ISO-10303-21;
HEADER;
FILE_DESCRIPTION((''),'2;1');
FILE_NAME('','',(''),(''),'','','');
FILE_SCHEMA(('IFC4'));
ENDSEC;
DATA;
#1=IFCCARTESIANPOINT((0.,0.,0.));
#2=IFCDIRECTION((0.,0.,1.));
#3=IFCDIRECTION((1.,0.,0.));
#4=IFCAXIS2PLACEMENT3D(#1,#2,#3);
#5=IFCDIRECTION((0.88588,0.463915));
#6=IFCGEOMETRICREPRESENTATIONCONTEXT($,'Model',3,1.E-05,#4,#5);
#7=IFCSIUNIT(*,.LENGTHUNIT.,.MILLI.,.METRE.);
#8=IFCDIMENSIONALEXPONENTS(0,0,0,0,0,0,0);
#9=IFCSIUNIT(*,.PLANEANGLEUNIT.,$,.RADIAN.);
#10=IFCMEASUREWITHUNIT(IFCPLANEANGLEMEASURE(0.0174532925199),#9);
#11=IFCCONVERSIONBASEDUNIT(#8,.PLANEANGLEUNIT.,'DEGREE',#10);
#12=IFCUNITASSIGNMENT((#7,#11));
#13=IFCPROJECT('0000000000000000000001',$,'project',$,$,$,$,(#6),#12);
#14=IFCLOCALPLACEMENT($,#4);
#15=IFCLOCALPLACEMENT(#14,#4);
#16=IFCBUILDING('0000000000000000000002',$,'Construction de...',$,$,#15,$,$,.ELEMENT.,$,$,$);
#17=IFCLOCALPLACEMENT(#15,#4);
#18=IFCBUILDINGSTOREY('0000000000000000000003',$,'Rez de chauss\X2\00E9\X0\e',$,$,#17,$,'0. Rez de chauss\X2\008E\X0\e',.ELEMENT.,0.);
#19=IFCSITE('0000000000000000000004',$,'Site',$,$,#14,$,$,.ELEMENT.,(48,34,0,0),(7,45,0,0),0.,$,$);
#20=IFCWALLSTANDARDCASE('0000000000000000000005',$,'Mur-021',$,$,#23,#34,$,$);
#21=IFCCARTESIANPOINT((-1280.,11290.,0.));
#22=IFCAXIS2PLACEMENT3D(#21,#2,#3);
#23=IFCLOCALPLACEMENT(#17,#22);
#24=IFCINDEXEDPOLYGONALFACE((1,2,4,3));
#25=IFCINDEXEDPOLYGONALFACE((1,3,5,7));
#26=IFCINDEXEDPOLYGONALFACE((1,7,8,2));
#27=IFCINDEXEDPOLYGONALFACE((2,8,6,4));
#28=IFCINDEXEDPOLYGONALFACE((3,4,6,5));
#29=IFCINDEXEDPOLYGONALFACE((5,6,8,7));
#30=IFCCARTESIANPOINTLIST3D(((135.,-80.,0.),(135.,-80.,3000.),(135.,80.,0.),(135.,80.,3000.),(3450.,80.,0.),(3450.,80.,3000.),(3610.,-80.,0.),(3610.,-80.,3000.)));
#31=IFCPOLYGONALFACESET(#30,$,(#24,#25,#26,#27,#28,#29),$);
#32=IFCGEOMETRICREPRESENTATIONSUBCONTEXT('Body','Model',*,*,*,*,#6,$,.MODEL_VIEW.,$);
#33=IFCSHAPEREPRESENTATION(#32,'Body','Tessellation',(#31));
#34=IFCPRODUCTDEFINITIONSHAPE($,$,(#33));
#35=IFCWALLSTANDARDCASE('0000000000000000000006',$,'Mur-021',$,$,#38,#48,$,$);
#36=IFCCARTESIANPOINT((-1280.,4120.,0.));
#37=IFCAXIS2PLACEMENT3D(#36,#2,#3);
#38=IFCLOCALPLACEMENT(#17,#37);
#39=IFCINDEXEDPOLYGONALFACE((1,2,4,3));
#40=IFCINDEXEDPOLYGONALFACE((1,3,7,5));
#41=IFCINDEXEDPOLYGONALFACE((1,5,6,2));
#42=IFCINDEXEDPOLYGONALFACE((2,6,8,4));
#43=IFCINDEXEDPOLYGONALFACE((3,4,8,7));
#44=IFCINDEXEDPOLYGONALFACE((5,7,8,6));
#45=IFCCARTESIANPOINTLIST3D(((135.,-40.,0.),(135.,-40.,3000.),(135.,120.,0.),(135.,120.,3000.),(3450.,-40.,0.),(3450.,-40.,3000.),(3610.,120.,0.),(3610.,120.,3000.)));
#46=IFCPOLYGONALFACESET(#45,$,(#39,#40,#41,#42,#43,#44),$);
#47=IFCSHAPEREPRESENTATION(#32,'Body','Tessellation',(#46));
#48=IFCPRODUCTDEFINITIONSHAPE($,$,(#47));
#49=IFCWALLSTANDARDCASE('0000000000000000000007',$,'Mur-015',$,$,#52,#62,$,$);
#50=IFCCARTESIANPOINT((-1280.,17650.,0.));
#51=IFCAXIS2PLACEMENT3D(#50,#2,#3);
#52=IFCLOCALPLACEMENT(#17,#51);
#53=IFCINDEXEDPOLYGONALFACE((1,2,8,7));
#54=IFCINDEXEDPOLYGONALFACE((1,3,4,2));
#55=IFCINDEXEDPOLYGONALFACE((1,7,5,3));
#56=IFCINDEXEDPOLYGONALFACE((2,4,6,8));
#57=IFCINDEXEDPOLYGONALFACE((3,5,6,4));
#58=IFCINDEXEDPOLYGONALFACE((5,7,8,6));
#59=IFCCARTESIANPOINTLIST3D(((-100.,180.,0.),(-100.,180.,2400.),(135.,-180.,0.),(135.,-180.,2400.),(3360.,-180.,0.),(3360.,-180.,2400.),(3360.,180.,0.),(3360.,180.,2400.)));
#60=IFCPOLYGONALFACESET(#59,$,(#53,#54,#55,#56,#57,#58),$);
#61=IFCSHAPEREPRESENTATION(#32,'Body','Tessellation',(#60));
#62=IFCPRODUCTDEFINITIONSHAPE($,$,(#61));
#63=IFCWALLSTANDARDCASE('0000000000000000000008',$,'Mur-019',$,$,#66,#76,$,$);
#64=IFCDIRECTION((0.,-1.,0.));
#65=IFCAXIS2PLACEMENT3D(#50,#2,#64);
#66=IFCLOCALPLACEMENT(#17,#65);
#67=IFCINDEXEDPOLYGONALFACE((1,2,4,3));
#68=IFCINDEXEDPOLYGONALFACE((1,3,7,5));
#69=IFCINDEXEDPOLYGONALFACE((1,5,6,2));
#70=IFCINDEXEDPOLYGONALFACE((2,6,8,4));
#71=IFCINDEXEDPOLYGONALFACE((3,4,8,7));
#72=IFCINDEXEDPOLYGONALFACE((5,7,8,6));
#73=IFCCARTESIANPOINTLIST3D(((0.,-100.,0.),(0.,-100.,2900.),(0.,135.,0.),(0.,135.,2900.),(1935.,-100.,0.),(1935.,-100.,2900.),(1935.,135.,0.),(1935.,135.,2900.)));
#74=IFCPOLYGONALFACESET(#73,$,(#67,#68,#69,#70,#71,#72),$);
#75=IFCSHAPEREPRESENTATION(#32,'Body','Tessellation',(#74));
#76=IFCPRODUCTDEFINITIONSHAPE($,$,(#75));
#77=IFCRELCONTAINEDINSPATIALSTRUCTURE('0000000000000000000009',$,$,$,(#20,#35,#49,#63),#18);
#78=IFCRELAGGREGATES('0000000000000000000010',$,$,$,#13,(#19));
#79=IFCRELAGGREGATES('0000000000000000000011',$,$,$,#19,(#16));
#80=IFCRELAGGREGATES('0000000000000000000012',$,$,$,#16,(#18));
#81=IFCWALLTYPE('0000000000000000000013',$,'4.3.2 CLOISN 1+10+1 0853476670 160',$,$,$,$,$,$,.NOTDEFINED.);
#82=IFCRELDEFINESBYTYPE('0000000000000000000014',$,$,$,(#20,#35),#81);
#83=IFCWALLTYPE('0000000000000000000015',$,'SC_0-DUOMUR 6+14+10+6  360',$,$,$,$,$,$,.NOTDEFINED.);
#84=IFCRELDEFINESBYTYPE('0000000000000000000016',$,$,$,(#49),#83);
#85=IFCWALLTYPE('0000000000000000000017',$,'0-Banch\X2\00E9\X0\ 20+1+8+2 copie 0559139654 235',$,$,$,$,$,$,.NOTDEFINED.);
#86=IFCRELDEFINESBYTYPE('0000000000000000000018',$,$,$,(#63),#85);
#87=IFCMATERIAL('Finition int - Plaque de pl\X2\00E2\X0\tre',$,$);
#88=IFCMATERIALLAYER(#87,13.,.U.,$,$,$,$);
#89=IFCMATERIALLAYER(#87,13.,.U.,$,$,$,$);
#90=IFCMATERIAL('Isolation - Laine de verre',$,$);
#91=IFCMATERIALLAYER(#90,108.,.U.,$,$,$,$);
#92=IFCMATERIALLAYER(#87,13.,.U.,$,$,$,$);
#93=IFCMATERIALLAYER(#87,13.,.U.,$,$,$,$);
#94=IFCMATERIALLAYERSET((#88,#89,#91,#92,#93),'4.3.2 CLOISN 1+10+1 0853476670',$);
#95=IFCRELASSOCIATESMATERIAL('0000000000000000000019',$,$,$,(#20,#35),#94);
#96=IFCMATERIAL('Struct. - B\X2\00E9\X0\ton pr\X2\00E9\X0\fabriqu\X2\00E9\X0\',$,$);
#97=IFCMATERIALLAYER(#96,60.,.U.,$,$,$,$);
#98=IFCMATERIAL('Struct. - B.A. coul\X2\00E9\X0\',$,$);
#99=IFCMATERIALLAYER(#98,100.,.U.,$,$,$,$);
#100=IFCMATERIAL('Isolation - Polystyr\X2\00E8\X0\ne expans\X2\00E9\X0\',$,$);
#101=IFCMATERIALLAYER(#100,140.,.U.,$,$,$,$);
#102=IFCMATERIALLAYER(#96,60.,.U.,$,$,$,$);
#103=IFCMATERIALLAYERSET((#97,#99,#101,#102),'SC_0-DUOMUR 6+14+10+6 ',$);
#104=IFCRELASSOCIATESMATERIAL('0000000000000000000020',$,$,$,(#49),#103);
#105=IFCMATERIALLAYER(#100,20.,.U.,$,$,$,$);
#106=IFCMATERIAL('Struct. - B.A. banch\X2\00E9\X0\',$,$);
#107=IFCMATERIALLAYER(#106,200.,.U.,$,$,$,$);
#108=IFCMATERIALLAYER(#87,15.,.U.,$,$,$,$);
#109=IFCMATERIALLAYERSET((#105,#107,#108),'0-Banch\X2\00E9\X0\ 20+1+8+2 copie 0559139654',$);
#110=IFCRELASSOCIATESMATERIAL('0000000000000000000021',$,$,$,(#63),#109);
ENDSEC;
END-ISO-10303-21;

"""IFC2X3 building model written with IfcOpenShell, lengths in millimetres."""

from ifc_helpers import new_model, entity, si_unit, converted_unit, direction, frame, origin_with_axes, place, context, subcontext, project, spatial, polyline, outline, extrude, clip, halfspace, material, layer, layer_set, layer_usage, type_object, element, save


model = new_model("IFC2X3")

# Units and contexts
model_context = context("Model", 3, precision=1e-05, world=origin_with_axes(), true_north=direction((0.88588, 0.463915)))
body_context = subcontext(model_context, "Body", "Model", "MODEL_VIEW")
ifc_project = project(units=[si_unit("LENGTHUNIT", "METRE", prefix="MILLI"), converted_unit("PLANEANGLEUNIT", "DEGREE", entity("IfcPlaneAngleMeasure", 0.0174532925199), si_unit("PLANEANGLEUNIT", "RADIAN"), dimensions=[0, 0, 0, 0, 0, 0, 0])], contexts=[model_context])

# Site, building, storey
site_placement = place(None, origin_with_axes())
site = spatial("IfcSite", under=ifc_project, at=site_placement, Name="Site", CompositionType="ELEMENT", RefLatitude=(48, 34, 0, 0), RefLongitude=(7, 45, 0, 0), RefElevation=0.0)
building_placement = place(site_placement, origin_with_axes())
building = spatial("IfcBuilding", under=site, at=building_placement, Name="Construction de...", CompositionType="ELEMENT")
storey_placement = place(building_placement, origin_with_axes())
storey = spatial("IfcBuildingStorey", under=building, at=storey_placement, Name="Rez de chaussée", LongName="0. Rez de chauss\u008ee", CompositionType="ELEMENT", Elevation=0.0)

# Shared definitions
ifc_material_1 = material(Name="Struct. - B.A. coulé")

# Wall
ifc_material_2 = material(Name="Finition int - Plaque de plâtre")
ifc_layer_1 = layer(ifc_material_2, 13.0, ventilated="UNKNOWN")
ifc_layer_2 = layer(ifc_material_2, 13.0, ventilated="UNKNOWN")
ifc_material_3 = material(Name="Isolation - Laine de verre")
ifc_layer_3 = layer(ifc_material_3, 108.0, ventilated="UNKNOWN")
ifc_layer_4 = layer(ifc_material_2, 13.0, ventilated="UNKNOWN")
ifc_layer_5 = layer(ifc_material_2, 13.0, ventilated="UNKNOWN")
ifc_layer_set_1 = layer_set([ifc_layer_1, ifc_layer_2, ifc_layer_3, ifc_layer_4, ifc_layer_5], Name="4.3.2 CLOISN 1+10+1 0853476670")
ifc_layer_usage_1 = layer_usage(ifc_layer_set_1, "AXIS2", "NEGATIVE", 80.0)
wall_type_1 = type_object("IfcWallType", Name="4.3.2 CLOISN 1+10+1 0853476670 160", PredefinedType="NOTDEFINED")
wall_1_placement = place(storey_placement, frame((-1280.0, 11290.0, 0.0), z_axis=(0.0, 0.0, 1.0), x_axis=(1.0, 0.0, 0.0)))
element("IfcWallStandardCase", 1, at=wall_1_placement, inside=storey, type_object=wall_type_1, material=ifc_layer_usage_1, Name="Mur-021", context=body_context, shape_type="SweptSolid", body=[
    extrude(outline(polyline([(135.0, -80.0), (3610.0, -80.0), (3450.0, 80.0), (135.0, 80.0), (135.0, -80.0)])), origin_with_axes(), (0.0, 0.0, 1.0), 3000.0),
])

# Wall
ifc_layer_usage_2 = layer_usage(ifc_layer_set_1, "AXIS2", "POSITIVE", -40.0)
wall_2_placement = place(storey_placement, frame((-1280.0, 4120.0, 0.0), z_axis=(0.0, 0.0, 1.0), x_axis=(1.0, 0.0, 0.0)))
element("IfcWallStandardCase", 2, at=wall_2_placement, inside=storey, type_object=wall_type_1, material=ifc_layer_usage_2, Name="Mur-021", context=body_context, shape_type="SweptSolid", body=[
    extrude(outline(polyline([(135.0, -40.0), (3450.0, -40.0), (3610.0, 120.0), (135.0, 120.0), (135.0, -40.0)])), origin_with_axes(), (0.0, 0.0, 1.0), 3000.0),
])
ifc_material_4 = material(Name="Struct. - B.A. banché")

# Shared definitions
ifc_material_5 = material(Name="Struct. - Béton préfabriqué")
ifc_layer_6 = layer(ifc_material_5, 60.0, ventilated="UNKNOWN")
ifc_layer_7 = layer(ifc_material_1, 100.0, ventilated="UNKNOWN")
ifc_material_6 = material(Name="Isolation - Polystyrène expansé")
ifc_layer_8 = layer(ifc_material_6, 140.0, ventilated="UNKNOWN")
ifc_layer_9 = layer(ifc_material_5, 60.0, ventilated="UNKNOWN")
ifc_layer_set_2 = layer_set([ifc_layer_6, ifc_layer_7, ifc_layer_8, ifc_layer_9], Name="SC_0-DUOMUR 6+14+10+6 ")
wall_type_2 = type_object("IfcWallType", Name="SC_0-DUOMUR 6+14+10+6  360", PredefinedType="NOTDEFINED")

# Walls
ifc_layer_usage_3 = layer_usage(ifc_layer_set_2, "AXIS2", "POSITIVE", -180.0)
wall_3_placement = place(storey_placement, frame((-1280.0, 17650.0, 0.0), z_axis=(0.0, 0.0, 1.0), x_axis=(1.0, 0.0, 0.0)))
element("IfcWallStandardCase", 3, at=wall_3_placement, inside=storey, type_object=wall_type_2, material=ifc_layer_usage_3, Name="Mur-015", context=body_context, shape_type="Clipping", body=[
    clip(extrude(outline(polyline([(135.0, -180.0), (3360.0, -180.0), (3360.0, 180.0), (-100.0, 180.0), (135.0, -180.0)])), origin_with_axes(), (0.0, 0.0, 1.0), 2400.0), halfspace(frame((-198.2, 0.0, 5285.8), z_axis=(0.037474, 0.0, -0.999298), x_axis=(0.0, 1.0, 0.0)), True)),
])
ifc_layer_10 = layer(ifc_material_6, 20.0, ventilated="UNKNOWN")
ifc_layer_11 = layer(ifc_material_4, 200.0, ventilated="UNKNOWN")
ifc_layer_12 = layer(ifc_material_2, 15.0, ventilated="UNKNOWN")
ifc_layer_set_3 = layer_set([ifc_layer_10, ifc_layer_11, ifc_layer_12], Name="0-Banché 20+1+8+2 copie 0559139654")
ifc_layer_usage_4 = layer_usage(ifc_layer_set_3, "AXIS2", "POSITIVE", -100.0)
wall_type_3 = type_object("IfcWallType", Name="0-Banché 20+1+8+2 copie 0559139654 235", PredefinedType="NOTDEFINED")
wall_4_placement = place(storey_placement, frame((-1280.0, 17650.0, 0.0), z_axis=(0.0, 0.0, 1.0), x_axis=(0.0, -1.0, 0.0)))
element("IfcWallStandardCase", 4, at=wall_4_placement, inside=storey, type_object=wall_type_3, material=ifc_layer_usage_4, Name="Mur-019", context=body_context, shape_type="SweptSolid", body=[
    extrude(outline(polyline([(0.0, -100.0), (1935.0, -100.0), (1935.0, 135.0), (0.0, 135.0), (0.0, -100.0)])), origin_with_axes(), (0.0, 0.0, 1.0), 2900.0),
])

save(model, "model.ifc")
